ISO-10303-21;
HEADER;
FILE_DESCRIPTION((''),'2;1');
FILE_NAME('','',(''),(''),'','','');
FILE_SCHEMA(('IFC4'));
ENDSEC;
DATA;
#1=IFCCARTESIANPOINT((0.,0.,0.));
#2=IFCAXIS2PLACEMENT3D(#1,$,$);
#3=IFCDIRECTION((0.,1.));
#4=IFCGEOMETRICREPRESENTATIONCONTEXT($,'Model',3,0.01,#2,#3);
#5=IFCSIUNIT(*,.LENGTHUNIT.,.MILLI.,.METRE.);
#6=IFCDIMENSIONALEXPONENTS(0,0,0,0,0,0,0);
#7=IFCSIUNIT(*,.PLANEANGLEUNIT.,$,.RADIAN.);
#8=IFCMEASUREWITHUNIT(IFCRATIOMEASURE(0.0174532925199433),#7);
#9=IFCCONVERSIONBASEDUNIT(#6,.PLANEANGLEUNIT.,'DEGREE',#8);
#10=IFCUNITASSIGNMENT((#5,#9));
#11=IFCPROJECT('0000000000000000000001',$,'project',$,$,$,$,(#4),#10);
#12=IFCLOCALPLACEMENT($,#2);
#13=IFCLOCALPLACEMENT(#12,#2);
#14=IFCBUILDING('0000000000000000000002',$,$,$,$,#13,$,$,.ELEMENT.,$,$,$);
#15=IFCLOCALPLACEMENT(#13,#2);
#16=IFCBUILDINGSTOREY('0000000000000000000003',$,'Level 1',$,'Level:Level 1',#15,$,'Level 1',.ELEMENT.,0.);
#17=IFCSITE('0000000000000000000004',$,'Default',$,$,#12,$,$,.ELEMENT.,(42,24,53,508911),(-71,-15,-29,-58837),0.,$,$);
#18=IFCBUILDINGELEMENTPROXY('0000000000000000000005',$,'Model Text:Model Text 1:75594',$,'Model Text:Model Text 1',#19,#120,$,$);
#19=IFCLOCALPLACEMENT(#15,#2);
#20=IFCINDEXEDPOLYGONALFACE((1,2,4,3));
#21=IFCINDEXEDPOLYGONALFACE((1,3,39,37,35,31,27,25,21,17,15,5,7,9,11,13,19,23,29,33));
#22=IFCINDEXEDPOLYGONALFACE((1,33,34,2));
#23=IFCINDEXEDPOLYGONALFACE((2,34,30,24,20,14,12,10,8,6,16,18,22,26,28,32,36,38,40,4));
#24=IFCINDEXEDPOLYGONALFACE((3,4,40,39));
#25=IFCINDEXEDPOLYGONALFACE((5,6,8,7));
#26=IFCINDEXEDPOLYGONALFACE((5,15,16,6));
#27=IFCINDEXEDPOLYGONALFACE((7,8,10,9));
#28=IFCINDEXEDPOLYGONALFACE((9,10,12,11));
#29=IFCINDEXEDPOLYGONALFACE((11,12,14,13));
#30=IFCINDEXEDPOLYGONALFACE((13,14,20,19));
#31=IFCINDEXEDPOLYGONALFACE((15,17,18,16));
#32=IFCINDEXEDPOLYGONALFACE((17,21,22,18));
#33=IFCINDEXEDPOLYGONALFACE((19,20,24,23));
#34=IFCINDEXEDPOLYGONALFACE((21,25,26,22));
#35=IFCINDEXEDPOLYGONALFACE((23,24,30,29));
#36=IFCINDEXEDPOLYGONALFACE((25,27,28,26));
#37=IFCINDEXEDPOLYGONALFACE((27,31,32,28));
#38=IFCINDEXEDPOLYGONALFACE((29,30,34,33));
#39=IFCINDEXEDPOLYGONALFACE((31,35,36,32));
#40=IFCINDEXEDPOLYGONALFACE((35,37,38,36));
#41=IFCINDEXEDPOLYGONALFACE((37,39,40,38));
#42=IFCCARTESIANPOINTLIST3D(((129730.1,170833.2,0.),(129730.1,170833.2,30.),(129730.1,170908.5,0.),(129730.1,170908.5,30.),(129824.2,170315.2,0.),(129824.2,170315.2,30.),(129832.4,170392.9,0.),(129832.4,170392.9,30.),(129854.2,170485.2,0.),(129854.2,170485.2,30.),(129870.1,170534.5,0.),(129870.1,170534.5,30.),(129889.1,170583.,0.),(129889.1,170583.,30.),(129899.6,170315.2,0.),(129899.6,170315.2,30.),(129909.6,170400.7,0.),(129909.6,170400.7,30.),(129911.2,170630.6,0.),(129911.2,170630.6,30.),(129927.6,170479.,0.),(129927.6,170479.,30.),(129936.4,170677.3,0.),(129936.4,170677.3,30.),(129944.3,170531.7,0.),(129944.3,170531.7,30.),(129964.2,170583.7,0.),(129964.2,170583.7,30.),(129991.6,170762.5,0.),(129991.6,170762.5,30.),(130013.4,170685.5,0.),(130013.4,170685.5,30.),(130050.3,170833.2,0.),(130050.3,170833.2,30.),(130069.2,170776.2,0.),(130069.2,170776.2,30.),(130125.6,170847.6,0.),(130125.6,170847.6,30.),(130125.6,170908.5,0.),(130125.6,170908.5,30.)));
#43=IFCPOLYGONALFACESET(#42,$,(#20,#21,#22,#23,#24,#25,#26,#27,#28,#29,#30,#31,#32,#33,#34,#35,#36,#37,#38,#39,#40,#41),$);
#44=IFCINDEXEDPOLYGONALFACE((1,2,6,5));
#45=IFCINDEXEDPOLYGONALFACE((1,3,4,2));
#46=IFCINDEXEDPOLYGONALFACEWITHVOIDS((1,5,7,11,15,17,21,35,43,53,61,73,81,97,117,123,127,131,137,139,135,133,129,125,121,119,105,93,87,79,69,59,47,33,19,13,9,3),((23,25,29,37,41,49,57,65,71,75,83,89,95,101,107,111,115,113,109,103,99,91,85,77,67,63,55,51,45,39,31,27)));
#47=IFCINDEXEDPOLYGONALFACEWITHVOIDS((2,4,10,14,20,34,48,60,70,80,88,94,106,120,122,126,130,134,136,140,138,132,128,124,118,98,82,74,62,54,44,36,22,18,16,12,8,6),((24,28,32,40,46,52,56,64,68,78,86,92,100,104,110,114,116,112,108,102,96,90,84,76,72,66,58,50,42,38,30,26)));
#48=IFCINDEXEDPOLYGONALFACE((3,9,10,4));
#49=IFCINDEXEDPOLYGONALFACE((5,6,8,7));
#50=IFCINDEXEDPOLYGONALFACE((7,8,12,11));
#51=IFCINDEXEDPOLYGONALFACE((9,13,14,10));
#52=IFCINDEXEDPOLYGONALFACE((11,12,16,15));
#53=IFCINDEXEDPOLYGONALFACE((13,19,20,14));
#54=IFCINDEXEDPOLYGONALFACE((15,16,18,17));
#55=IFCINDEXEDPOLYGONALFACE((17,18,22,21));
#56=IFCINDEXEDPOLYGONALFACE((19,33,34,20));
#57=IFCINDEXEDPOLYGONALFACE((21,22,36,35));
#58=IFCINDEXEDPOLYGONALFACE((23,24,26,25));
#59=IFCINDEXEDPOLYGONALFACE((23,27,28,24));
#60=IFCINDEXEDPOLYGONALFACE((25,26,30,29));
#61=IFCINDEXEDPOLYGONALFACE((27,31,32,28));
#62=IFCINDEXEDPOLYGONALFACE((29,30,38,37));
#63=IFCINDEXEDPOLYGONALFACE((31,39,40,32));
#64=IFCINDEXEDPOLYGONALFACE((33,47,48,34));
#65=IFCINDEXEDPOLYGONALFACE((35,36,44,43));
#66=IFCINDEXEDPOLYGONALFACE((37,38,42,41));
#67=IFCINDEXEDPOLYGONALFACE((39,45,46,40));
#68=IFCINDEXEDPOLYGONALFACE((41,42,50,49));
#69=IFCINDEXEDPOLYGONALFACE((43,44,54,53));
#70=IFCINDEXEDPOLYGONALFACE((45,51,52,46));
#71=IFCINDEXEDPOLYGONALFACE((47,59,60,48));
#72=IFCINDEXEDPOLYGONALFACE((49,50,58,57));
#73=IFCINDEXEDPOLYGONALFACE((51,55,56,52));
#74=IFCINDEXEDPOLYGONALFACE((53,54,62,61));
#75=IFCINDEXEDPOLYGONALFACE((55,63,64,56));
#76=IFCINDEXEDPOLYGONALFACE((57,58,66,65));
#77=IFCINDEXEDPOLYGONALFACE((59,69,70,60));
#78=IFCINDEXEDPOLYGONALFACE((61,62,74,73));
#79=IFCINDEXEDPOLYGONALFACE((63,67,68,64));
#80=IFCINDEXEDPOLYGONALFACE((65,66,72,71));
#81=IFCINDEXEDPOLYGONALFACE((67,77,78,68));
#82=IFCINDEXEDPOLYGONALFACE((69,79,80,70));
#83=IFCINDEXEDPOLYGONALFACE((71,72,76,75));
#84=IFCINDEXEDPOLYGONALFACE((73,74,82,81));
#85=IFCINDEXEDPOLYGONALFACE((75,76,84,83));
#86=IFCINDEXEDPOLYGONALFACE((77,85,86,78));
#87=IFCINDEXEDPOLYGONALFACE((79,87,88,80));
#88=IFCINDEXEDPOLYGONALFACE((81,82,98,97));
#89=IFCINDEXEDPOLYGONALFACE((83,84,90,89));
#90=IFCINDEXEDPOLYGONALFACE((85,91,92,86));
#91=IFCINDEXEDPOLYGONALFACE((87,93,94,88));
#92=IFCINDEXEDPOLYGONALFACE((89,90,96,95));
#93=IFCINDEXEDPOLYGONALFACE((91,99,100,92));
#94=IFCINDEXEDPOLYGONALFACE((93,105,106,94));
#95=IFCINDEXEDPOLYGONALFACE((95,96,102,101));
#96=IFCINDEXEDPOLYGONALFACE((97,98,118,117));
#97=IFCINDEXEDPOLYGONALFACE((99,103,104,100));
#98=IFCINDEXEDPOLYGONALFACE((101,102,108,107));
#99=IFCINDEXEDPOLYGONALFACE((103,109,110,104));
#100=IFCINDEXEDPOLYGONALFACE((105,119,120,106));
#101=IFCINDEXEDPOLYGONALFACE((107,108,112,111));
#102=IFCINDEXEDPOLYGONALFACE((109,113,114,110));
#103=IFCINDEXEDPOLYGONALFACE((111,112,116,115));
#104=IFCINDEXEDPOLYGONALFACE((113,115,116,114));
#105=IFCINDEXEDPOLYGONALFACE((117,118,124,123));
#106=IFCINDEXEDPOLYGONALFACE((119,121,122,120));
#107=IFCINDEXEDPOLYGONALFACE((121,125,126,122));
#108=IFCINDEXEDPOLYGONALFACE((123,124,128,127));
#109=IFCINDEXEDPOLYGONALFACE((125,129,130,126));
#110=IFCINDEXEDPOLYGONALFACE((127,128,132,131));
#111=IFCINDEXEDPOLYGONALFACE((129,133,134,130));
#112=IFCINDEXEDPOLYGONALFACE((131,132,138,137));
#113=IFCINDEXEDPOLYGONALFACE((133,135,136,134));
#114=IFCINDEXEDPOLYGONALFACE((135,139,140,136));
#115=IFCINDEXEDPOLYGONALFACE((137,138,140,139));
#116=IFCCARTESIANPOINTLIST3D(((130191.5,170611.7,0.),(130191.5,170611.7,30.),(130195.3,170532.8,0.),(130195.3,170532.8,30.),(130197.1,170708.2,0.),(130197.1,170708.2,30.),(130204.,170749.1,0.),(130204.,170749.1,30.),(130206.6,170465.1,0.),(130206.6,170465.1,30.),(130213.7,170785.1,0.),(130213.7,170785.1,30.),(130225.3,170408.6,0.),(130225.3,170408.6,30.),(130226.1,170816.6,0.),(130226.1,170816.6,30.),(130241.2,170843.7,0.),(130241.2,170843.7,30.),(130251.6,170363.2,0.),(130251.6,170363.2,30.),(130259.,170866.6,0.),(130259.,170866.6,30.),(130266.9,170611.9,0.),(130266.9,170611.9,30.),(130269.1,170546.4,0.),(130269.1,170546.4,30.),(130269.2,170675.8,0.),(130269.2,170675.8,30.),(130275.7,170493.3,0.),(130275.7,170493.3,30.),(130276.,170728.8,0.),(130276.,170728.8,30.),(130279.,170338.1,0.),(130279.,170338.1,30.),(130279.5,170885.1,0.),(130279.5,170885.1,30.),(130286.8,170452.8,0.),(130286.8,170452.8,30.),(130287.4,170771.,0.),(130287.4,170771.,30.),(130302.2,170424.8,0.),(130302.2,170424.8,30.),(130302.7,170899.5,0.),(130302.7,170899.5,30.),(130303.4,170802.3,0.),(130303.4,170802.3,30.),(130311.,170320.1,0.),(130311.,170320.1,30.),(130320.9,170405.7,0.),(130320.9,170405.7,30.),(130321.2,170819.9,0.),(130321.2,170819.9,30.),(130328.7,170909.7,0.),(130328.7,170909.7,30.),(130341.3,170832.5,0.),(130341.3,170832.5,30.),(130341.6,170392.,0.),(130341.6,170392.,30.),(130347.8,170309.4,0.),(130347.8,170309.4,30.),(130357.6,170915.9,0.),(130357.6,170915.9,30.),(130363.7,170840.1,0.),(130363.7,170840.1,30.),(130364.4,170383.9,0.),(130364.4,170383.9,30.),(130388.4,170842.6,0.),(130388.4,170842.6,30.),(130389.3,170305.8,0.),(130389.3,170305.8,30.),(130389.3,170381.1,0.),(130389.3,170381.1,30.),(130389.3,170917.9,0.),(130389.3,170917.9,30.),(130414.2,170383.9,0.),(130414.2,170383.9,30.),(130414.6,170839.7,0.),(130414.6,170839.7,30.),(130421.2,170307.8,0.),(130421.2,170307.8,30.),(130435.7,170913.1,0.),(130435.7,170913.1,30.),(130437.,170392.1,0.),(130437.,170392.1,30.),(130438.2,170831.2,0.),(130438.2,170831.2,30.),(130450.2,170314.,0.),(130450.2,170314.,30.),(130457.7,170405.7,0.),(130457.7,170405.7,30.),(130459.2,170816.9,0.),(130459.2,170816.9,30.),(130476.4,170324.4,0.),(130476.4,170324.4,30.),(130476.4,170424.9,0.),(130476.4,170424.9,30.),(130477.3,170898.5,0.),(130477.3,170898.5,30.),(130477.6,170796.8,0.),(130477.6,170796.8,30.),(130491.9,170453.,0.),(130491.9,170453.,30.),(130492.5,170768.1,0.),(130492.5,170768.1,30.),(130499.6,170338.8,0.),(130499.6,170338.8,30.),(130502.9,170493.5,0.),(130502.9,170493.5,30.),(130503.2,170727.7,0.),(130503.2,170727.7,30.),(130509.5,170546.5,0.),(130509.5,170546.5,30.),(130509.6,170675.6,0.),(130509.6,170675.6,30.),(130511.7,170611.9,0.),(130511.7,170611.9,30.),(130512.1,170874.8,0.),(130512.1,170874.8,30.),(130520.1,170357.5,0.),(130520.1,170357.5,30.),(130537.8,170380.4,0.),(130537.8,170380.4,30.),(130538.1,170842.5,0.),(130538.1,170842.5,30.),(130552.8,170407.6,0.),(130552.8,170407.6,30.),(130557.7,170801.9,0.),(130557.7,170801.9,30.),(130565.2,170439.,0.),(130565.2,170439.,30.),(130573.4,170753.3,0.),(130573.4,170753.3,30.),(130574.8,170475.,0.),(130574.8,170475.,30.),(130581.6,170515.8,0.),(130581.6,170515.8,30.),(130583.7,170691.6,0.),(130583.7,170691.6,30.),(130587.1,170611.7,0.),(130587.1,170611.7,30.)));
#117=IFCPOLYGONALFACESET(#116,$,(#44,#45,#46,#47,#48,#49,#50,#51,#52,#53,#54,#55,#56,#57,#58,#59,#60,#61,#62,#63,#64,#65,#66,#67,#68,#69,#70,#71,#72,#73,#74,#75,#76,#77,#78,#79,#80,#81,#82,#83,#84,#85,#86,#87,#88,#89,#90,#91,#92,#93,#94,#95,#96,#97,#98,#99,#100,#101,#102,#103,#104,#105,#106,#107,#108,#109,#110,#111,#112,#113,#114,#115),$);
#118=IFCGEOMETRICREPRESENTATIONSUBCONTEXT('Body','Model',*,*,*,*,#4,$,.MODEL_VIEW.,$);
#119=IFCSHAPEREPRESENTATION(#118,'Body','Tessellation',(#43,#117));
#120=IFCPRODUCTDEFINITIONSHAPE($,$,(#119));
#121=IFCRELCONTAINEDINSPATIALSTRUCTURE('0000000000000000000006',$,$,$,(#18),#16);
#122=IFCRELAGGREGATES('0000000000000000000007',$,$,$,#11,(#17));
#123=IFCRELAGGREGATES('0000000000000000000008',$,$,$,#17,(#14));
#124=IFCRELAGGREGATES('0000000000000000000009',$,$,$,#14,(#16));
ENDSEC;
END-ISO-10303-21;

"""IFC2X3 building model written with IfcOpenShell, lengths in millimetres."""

from ifc_helpers import new_model, entity, si_unit, converted_unit, direction, frame, origin, place, context, subcontext, project, spatial, polyline, outline, extrude, element, save


model = new_model("IFC2X3")

# Units and contexts
model_context = context("Model", 3, precision=0.01, world=origin(), true_north=direction((0.0, 1.0)))
body_context = subcontext(model_context, "Body", "Model", "MODEL_VIEW")
ifc_project = project(units=[si_unit("LENGTHUNIT", "METRE", prefix="MILLI"), converted_unit("PLANEANGLEUNIT", "DEGREE", entity("IfcRatioMeasure", 0.0174532925199433), si_unit("PLANEANGLEUNIT", "RADIAN"), dimensions=[0, 0, 0, 0, 0, 0, 0])], contexts=[model_context])

# Site, building, storey
site_placement = place(None, origin())
site = spatial("IfcSite", under=ifc_project, at=site_placement, Name="Default", CompositionType="ELEMENT", RefLatitude=(42, 24, 53, 508911), RefLongitude=(-71, -15, -29, -58837), RefElevation=0.0)
building_placement = place(site_placement, origin())
building = spatial("IfcBuilding", under=site, at=building_placement, CompositionType="ELEMENT")
storey_placement = place(building_placement, origin())
storey = spatial("IfcBuildingStorey", under=building, at=storey_placement, Name="Level 1", ObjectType="Level:Level 1", LongName="Level 1", CompositionType="ELEMENT", Elevation=0.0)

# Building element proxy
proxy_1_placement = place(storey_placement, origin())
element("IfcBuildingElementProxy", 1, at=proxy_1_placement, inside=storey, Name="Model Text:Model Text 1:75594", ObjectType="Model Text:Model Text 1", context=body_context, shape_type="SweptSolid", body=[
    extrude(outline(polyline([(-199.9, -209.0), (-199.9, -284.3), (195.7, -284.3), (195.7, -223.4), (139.3, -152.0), (83.5, -61.3), (34.2, 40.5), (14.4, 92.5), (-2.4, 145.2), (-20.3, 223.5), (-30.3, 309.0), (-105.7, 309.0), (-97.5, 231.3), (-75.7, 139.0), (-59.9, 89.7), (-40.9, 41.2), (-18.8, -6.4), (6.4, -53.1), (61.7, -138.3), (120.3, -209.0), (-199.9, -209.0)])), frame((129929.9, 170624.2, 0.0), z_axis=(0.0, 0.0, -1.0), x_axis=(1.0, 0.0, 0.0)), (0.0, 0.0, -1.0), 30.0),
    extrude(outline(polyline([(-10.6, -198.7), (68.3, -198.7), (136.5, -190.7), (193.9, -174.7), (240.5, -150.6), (266.9, -124.4), (286.3, -93.2), (298.8, -57.0), (304.3, -15.7), (303.8, 16.2), (299.0, 45.5), (289.9, 72.1), (276.6, 96.0), (258.9, 117.3), (236.9, 136.2), (210.4, 152.5), (179.6, 166.3), (144.1, 177.6), (103.7, 186.3), (8.2, 196.4), (-71.8, 196.7), (-134.0, 189.4), (-183.3, 176.1), (-224.7, 158.4), (-258.2, 133.9), (-283.5, 100.3), (-300.1, 59.5), (-307.1, 13.4), (-306.6, -18.4), (-301.8, -47.5), (-292.8, -74.0), (-279.6, -97.9), (-262.0, -119.2), (-240.0, -138.1), (-213.6, -154.5), (-182.8, -168.4), (-147.3, -179.8), (-106.7, -188.6), (-10.6, -198.7)]), holes=[polyline([(-7.2, -123.5), (-71.0, -118.2), (-123.6, -108.8), (-165.2, -95.4), (-195.7, -78.0), (-212.4, -59.4), (-224.1, -38.7), (-230.6, -15.9), (-231.9, 8.9), (-227.8, 35.0), (-218.1, 58.1), (-202.8, 78.4), (-182.0, 95.8), (-152.6, 109.4), (-111.7, 118.1), (-59.4, 122.0), (4.4, 121.1), (69.6, 115.8), (122.2, 106.7), (162.2, 93.7), (189.5, 77.0), (207.7, 57.4), (220.4, 36.0), (227.5, 12.8), (229.1, -12.1), (225.2, -36.8), (215.9, -59.2), (201.3, -79.3), (181.4, -97.1), (152.6, -111.2), (111.6, -120.3), (58.3, -124.4), (-7.2, -123.5)])]), frame((130390.6, 170610.5, 0.0), z_axis=(0.0, 0.0, 1.0), x_axis=(0.047515, -0.998871, 0.0)), (0.0, 0.0, 1.0), 30.0),
])

save(model, "model.ifc")
